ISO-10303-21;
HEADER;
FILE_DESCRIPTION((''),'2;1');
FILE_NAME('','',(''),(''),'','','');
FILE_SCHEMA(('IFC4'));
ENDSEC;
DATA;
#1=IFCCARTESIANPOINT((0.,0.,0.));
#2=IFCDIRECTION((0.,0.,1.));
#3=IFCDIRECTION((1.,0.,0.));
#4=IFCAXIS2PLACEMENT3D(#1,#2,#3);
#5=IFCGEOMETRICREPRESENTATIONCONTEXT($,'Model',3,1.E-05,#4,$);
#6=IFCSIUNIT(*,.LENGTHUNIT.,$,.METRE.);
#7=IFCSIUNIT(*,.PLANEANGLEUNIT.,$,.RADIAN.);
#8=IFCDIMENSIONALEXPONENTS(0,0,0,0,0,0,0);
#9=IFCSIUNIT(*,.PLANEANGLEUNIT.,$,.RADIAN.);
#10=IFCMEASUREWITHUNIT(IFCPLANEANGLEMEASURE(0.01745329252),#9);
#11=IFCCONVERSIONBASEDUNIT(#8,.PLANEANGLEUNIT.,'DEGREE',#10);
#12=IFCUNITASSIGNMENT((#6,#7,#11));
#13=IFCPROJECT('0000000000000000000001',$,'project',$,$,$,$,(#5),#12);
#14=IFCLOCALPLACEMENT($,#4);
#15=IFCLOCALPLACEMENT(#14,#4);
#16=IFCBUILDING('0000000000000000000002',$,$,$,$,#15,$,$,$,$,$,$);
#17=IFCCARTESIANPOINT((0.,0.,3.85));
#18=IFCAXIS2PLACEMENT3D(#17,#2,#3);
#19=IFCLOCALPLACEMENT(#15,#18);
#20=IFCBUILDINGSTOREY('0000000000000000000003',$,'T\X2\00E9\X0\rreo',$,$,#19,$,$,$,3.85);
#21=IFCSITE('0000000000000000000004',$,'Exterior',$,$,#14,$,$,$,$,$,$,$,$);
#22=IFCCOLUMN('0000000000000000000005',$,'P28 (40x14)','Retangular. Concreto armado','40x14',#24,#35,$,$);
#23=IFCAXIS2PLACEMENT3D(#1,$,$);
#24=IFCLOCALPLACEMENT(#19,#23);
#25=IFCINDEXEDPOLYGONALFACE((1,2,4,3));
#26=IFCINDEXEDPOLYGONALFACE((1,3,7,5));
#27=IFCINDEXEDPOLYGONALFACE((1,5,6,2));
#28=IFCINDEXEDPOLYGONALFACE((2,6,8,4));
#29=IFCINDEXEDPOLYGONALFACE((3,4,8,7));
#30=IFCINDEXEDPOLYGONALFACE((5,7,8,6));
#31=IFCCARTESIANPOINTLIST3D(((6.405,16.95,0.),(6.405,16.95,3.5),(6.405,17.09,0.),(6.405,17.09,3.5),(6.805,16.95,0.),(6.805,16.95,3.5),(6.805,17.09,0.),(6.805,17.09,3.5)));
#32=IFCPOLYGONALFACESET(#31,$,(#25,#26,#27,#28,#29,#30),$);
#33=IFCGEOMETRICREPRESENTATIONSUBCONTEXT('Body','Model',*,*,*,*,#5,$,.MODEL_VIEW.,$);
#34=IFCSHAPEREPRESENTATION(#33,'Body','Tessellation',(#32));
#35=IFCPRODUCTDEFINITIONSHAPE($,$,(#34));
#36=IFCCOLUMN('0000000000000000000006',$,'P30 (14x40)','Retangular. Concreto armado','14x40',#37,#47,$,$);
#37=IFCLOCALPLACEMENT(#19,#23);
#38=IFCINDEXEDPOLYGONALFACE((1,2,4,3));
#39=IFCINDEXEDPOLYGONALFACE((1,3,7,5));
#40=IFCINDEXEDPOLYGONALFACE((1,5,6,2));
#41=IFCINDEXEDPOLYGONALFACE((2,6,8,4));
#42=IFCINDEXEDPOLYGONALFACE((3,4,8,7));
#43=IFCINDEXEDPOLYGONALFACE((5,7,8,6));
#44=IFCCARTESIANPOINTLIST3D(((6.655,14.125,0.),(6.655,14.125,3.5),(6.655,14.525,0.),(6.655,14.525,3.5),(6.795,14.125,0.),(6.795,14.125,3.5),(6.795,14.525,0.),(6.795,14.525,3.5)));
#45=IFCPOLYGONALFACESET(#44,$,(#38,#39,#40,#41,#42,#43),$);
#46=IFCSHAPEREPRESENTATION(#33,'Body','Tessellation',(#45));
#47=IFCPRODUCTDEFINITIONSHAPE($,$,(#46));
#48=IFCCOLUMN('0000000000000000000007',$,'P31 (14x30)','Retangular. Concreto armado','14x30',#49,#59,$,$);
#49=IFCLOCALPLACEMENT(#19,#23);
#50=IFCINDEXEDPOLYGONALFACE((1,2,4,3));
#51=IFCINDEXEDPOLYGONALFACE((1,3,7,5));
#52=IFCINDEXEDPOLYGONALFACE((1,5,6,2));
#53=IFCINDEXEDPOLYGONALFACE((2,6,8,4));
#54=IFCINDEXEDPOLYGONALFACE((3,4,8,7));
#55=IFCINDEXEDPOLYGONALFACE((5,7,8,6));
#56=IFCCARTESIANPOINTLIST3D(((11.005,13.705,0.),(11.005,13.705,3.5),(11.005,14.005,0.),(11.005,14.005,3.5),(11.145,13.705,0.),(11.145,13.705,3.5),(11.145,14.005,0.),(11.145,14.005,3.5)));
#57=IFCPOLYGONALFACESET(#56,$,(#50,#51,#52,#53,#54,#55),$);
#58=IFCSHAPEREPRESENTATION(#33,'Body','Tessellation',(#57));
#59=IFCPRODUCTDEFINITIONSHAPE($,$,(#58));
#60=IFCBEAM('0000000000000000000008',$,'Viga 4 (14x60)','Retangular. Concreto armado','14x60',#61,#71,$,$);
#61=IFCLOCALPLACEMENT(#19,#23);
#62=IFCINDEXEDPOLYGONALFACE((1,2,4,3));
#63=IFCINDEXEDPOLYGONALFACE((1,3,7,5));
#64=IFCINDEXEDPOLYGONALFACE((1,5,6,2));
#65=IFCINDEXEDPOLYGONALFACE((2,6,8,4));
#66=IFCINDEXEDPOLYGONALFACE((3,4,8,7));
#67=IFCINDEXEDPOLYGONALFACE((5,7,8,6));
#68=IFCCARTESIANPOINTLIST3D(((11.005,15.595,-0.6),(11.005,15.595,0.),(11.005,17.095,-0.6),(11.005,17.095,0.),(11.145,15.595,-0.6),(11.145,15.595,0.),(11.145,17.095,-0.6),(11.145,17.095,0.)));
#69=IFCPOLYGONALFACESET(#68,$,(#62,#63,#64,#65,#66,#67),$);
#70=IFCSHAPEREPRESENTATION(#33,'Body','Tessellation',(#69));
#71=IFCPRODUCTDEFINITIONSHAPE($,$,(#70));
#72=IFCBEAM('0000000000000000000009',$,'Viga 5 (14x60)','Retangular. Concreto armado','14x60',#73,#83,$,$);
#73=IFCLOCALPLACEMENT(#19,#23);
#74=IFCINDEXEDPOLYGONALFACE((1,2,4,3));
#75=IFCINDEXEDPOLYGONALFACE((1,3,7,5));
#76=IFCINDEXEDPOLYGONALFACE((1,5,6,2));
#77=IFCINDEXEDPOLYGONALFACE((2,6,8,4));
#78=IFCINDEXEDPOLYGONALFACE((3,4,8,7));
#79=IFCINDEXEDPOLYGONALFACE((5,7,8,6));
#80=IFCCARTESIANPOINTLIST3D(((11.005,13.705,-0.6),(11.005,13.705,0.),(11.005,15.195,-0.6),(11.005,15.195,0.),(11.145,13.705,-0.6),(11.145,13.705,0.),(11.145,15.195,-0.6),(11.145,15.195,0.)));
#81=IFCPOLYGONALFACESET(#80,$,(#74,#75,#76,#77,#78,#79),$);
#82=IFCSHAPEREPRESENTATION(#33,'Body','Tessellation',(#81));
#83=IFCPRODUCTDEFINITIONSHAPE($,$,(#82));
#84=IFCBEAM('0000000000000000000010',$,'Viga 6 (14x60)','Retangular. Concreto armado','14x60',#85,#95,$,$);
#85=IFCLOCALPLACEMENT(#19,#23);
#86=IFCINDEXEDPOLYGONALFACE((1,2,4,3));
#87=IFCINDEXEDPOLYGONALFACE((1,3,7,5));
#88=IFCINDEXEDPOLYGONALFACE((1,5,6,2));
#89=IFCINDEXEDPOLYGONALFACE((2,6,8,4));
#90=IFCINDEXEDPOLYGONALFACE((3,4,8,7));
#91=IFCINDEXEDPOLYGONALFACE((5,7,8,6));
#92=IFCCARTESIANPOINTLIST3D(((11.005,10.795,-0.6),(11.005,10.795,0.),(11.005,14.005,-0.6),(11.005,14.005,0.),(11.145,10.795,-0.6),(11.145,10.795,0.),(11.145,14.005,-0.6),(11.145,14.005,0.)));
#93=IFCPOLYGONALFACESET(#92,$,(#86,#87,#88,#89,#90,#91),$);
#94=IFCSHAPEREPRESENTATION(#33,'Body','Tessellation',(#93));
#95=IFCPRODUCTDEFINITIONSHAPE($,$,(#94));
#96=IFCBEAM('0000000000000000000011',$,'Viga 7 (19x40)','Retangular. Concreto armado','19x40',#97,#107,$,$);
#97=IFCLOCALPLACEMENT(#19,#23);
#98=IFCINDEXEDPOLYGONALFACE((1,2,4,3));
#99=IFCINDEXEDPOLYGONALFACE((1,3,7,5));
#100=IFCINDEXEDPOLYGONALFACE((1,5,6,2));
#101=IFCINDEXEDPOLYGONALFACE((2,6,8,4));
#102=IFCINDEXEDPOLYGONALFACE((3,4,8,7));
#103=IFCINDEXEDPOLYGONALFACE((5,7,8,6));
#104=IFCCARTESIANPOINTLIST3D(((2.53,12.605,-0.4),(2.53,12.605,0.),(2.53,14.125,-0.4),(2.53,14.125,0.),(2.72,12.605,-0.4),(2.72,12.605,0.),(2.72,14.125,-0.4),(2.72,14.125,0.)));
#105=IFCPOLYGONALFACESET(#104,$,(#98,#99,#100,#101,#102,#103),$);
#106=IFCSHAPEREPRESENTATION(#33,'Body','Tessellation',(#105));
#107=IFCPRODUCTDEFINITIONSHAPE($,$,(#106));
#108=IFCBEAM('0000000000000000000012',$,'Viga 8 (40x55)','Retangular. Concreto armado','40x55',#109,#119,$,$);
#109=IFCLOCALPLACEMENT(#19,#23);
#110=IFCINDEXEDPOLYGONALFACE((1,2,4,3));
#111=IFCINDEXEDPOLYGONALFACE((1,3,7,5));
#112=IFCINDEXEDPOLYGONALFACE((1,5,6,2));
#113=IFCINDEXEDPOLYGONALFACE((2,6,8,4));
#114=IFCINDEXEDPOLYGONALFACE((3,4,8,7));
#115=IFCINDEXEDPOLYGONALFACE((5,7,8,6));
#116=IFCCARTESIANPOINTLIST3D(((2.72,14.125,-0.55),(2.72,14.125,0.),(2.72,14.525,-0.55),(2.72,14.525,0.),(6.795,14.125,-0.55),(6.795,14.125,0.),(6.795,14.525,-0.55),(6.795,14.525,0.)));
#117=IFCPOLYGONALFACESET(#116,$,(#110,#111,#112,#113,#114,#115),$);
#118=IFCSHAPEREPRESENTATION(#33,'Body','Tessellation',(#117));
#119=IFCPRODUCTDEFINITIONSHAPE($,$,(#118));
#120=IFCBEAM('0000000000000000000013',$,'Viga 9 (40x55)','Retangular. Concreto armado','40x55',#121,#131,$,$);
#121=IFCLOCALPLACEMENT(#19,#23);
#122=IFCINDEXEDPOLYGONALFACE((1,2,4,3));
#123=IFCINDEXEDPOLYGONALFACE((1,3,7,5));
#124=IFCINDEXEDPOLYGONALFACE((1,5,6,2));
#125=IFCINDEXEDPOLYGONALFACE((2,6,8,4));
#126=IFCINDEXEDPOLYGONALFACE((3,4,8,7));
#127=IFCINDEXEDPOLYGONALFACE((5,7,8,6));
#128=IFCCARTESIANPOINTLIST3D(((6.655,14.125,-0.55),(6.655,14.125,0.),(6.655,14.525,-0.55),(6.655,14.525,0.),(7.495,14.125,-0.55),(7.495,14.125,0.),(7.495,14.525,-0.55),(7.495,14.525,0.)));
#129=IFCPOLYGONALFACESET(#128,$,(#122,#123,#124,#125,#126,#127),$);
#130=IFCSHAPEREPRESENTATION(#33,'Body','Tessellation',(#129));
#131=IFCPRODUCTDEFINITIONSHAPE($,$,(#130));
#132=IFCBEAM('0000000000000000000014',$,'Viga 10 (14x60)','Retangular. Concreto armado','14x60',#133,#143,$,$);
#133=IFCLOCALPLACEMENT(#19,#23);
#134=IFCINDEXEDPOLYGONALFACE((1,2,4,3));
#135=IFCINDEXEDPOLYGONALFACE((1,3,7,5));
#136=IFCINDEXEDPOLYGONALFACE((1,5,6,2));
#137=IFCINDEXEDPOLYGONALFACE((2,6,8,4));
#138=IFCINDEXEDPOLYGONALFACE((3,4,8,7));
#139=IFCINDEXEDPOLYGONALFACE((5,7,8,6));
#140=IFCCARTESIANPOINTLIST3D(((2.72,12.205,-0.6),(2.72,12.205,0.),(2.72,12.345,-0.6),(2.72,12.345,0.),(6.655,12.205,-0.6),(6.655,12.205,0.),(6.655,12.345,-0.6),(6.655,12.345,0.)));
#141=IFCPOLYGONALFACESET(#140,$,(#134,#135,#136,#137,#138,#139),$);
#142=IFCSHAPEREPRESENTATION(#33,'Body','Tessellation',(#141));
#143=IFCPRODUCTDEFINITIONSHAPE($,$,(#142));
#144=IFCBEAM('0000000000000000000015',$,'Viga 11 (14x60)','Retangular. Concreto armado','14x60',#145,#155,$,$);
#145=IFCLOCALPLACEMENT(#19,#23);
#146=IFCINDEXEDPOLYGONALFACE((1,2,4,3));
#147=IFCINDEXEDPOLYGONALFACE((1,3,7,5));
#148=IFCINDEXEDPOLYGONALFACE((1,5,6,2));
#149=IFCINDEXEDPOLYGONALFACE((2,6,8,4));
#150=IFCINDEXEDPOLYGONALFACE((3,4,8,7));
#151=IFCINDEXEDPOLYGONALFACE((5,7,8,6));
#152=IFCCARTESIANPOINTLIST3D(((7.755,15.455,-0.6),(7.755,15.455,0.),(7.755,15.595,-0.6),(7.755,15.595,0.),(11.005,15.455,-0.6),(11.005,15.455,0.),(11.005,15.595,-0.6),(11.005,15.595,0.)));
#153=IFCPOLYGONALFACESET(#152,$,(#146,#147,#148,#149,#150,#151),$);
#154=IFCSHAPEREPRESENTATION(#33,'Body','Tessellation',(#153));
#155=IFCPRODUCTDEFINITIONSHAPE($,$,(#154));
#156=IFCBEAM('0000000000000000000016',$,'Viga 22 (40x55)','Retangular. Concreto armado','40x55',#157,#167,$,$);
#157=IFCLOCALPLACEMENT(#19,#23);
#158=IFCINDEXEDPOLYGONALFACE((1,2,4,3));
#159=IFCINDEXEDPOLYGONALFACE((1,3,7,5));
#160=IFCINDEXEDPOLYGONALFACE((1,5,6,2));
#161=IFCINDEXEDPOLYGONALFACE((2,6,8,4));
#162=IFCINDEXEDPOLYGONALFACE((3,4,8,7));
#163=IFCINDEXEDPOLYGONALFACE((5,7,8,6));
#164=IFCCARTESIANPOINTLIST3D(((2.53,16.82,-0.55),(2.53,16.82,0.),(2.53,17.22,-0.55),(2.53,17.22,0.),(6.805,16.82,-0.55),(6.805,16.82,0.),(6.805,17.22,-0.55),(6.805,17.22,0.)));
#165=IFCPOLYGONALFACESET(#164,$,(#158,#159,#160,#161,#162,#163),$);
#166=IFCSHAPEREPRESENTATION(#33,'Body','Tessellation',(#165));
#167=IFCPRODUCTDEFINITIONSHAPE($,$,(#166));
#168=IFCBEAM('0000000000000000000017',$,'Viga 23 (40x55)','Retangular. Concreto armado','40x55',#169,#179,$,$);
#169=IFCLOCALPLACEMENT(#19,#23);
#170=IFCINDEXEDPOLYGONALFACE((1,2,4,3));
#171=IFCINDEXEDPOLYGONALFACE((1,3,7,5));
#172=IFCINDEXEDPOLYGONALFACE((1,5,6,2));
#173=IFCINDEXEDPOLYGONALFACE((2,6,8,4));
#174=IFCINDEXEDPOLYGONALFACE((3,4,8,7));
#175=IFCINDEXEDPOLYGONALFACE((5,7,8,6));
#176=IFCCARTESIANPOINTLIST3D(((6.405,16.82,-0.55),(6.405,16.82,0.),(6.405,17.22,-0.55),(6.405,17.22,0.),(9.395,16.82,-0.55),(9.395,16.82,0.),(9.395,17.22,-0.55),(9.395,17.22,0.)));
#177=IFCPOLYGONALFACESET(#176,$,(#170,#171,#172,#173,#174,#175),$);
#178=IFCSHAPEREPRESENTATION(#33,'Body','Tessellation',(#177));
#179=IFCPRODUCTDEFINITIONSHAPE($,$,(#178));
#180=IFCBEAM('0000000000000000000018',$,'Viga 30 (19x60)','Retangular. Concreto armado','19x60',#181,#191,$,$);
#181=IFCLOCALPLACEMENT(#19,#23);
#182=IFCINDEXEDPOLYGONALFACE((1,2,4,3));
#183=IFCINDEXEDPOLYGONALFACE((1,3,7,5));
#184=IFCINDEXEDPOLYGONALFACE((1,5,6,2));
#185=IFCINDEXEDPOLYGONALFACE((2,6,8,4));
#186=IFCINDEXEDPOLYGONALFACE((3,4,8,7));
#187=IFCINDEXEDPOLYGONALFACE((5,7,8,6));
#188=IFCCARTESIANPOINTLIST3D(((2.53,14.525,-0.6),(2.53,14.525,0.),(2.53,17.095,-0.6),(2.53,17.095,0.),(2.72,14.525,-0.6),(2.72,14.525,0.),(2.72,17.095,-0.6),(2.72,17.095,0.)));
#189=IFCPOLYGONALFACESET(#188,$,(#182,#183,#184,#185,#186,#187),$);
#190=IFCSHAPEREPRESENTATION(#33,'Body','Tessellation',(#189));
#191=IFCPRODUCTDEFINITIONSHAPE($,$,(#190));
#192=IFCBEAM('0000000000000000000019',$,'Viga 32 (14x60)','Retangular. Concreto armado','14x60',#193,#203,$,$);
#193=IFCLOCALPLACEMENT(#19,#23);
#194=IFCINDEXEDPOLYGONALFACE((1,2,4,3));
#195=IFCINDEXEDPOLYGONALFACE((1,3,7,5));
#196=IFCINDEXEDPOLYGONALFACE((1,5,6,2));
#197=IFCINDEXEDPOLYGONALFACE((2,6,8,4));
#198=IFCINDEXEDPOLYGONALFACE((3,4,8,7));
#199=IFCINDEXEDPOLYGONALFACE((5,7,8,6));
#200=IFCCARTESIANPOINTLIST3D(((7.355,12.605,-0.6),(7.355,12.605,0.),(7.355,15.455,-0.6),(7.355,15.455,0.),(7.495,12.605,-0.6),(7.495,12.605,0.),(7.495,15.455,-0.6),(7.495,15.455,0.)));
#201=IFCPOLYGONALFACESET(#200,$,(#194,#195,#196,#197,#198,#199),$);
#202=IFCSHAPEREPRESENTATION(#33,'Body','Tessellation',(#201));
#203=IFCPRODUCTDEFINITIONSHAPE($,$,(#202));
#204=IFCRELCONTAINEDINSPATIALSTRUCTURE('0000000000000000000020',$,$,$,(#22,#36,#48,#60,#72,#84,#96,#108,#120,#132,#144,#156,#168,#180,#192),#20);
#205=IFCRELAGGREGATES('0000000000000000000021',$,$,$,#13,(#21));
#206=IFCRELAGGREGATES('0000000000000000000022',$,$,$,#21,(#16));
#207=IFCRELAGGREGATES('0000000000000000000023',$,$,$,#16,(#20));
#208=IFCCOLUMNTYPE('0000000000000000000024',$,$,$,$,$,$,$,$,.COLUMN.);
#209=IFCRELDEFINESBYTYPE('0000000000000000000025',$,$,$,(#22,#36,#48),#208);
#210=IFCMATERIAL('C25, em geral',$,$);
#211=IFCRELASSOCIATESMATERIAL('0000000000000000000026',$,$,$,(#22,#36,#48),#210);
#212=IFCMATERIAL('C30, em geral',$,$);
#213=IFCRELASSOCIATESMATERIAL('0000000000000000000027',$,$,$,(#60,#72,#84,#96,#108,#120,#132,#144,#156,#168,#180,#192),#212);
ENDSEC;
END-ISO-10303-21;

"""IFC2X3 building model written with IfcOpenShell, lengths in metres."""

from ifc_helpers import new_model, entity, si_unit, converted_unit, frame, frame_2d, origin_with_axes, place, context, subcontext, project, spatial, rectangle, extrude, material, type_object, element, save


model = new_model("IFC2X3")

# Units and contexts
model_context = context("Model", 3, precision=1e-05, world=origin_with_axes())
body_context = subcontext(model_context, "Body", "Model", "MODEL_VIEW")
ifc_project = project(units=[si_unit("LENGTHUNIT", "METRE"), si_unit("PLANEANGLEUNIT", "RADIAN"), converted_unit("PLANEANGLEUNIT", "DEGREE", entity("IfcPlaneAngleMeasure", 0.01745329252), si_unit("PLANEANGLEUNIT", "RADIAN"), dimensions=[0, 0, 0, 0, 0, 0, 0])], contexts=[model_context])

# Site, building, storey
site_placement = place(None, origin_with_axes())
site = spatial("IfcSite", under=ifc_project, at=site_placement, Name="Exterior")
building_placement = place(site_placement, origin_with_axes())
building = spatial("IfcBuilding", under=site, at=building_placement)
storey_placement = place(building_placement, frame((0.0, 0.0, 3.85), z_axis=(0.0, 0.0, 1.0), x_axis=(1.0, 0.0, 0.0)))
storey = spatial("IfcBuildingStorey", under=building, at=storey_placement, Name="Térreo", Elevation=3.85)

# Columns
ifc_material_1 = material(Name="C25, em geral")
column_type = type_object("IfcColumnType", PredefinedType="COLUMN")
column_1_placement = place(storey_placement, frame((6.405, 16.95, 0.0), z_axis=(0.0, 0.0, 1.0), x_axis=(1.0, 0.0, 0.0)))
element("IfcColumn", 1, at=column_1_placement, inside=storey, type_object=column_type, material=ifc_material_1, Name="P28 (40x14)", Description="Retangular. Concreto armado", ObjectType="40x14", context=body_context, shape_type="SweptSolid", body=[
    extrude(rectangle(XDim=0.4, YDim=0.14, at=frame_2d((0.2, 0.07), x_axis=(1.0, 0.0))), origin_with_axes(), (0.0, 0.0, 1.0), 3.5),
])
column_2_placement = place(storey_placement, frame((6.795, 14.525, 0.0), z_axis=(0.0, 0.0, 1.0), x_axis=(1.0, 0.0, 0.0)))
element("IfcColumn", 2, at=column_2_placement, inside=storey, type_object=column_type, material=ifc_material_1, Name="P30 (14x40)", Description="Retangular. Concreto armado", ObjectType="14x40", context=body_context, shape_type="SweptSolid", body=[
    extrude(rectangle(XDim=0.14, YDim=0.4, at=frame_2d((-0.07, -0.2), x_axis=(1.0, 0.0))), origin_with_axes(), (0.0, 0.0, 1.0), 3.5),
])
column_3_placement = place(storey_placement, frame((11.005, 13.705, 0.0), z_axis=(0.0, 0.0, 1.0), x_axis=(1.0, 0.0, 0.0)))
element("IfcColumn", 3, at=column_3_placement, inside=storey, type_object=column_type, material=ifc_material_1, Name="P31 (14x30)", Description="Retangular. Concreto armado", ObjectType="14x30", context=body_context, shape_type="SweptSolid", body=[
    extrude(rectangle(XDim=0.14, YDim=0.3, at=frame_2d((0.07, 0.15), x_axis=(1.0, 0.0))), origin_with_axes(), (0.0, 0.0, 1.0), 3.5),
])

# Beams
ifc_material_2 = material(Name="C30, em geral")
beam_1_placement = place(storey_placement, frame((11.075, 17.095, 0.0), z_axis=(0.0, -1.0, 0.0), x_axis=(1.0, 0.0, 0.0)))
element("IfcBeam", 4, at=beam_1_placement, inside=storey, material=ifc_material_2, Name="Viga 4 (14x60)", Description="Retangular. Concreto armado", ObjectType="14x60", context=body_context, shape_type="SweptSolid", body=[
    extrude(rectangle(XDim=0.14, YDim=0.6, at=frame_2d((0.0, -0.3), x_axis=(1.0, 0.0))), origin_with_axes(), (0.0, 0.0, 1.0), 1.5),
])
beam_2_placement = place(storey_placement, frame((11.075, 15.195, 0.0), z_axis=(0.0, -1.0, 0.0), x_axis=(1.0, 0.0, 0.0)))
element("IfcBeam", 5, at=beam_2_placement, inside=storey, material=ifc_material_2, Name="Viga 5 (14x60)", Description="Retangular. Concreto armado", ObjectType="14x60", context=body_context, shape_type="SweptSolid", body=[
    extrude(rectangle(XDim=0.14, YDim=0.6, at=frame_2d((0.0, -0.3), x_axis=(1.0, 0.0))), origin_with_axes(), (0.0, 0.0, 1.0), 1.49),
])
beam_3_placement = place(storey_placement, frame((11.075, 14.005, 0.0), z_axis=(0.0, -1.0, 0.0), x_axis=(1.0, 0.0, 0.0)))
element("IfcBeam", 6, at=beam_3_placement, inside=storey, material=ifc_material_2, Name="Viga 6 (14x60)", Description="Retangular. Concreto armado", ObjectType="14x60", context=body_context, shape_type="SweptSolid", body=[
    extrude(rectangle(XDim=0.14, YDim=0.6, at=frame_2d((0.0, -0.3), x_axis=(1.0, 0.0))), origin_with_axes(), (0.0, 0.0, 1.0), 3.21),
])
beam_4_placement = place(storey_placement, frame((2.625, 14.125, 0.0), z_axis=(0.0, -1.0, 0.0), x_axis=(1.0, 0.0, 0.0)))
element("IfcBeam", 7, at=beam_4_placement, inside=storey, material=ifc_material_2, Name="Viga 7 (19x40)", Description="Retangular. Concreto armado", ObjectType="19x40", context=body_context, shape_type="SweptSolid", body=[
    extrude(rectangle(XDim=0.19, YDim=0.4, at=frame_2d((0.0, -0.2), x_axis=(1.0, 0.0))), origin_with_axes(), (0.0, 0.0, 1.0), 1.52),
])
beam_5_placement = place(storey_placement, frame((2.72, 14.325, 0.0), z_axis=(1.0, 0.0, 0.0), x_axis=(0.0, 1.0, 0.0)))
element("IfcBeam", 8, at=beam_5_placement, inside=storey, material=ifc_material_2, Name="Viga 8 (40x55)", Description="Retangular. Concreto armado", ObjectType="40x55", context=body_context, shape_type="SweptSolid", body=[
    extrude(rectangle(XDim=0.4, YDim=0.55, at=frame_2d((0.0, -0.275), x_axis=(1.0, 0.0))), origin_with_axes(), (0.0, 0.0, 1.0), 4.075),
])
beam_6_placement = place(storey_placement, frame((6.655, 14.325, 0.0), z_axis=(1.0, 0.0, 0.0), x_axis=(0.0, 1.0, 0.0)))
element("IfcBeam", 9, at=beam_6_placement, inside=storey, material=ifc_material_2, Name="Viga 9 (40x55)", Description="Retangular. Concreto armado", ObjectType="40x55", context=body_context, shape_type="SweptSolid", body=[
    extrude(rectangle(XDim=0.4, YDim=0.55, at=frame_2d((0.0, -0.275), x_axis=(1.0, 0.0))), origin_with_axes(), (0.0, 0.0, 1.0), 0.84),
])
beam_7_placement = place(storey_placement, frame((2.72, 12.275, 0.0), z_axis=(1.0, 0.0, 0.0), x_axis=(0.0, 1.0, 0.0)))
element("IfcBeam", 10, at=beam_7_placement, inside=storey, material=ifc_material_2, Name="Viga 10 (14x60)", Description="Retangular. Concreto armado", ObjectType="14x60", context=body_context, shape_type="SweptSolid", body=[
    extrude(rectangle(XDim=0.14, YDim=0.6, at=frame_2d((0.0, -0.3), x_axis=(1.0, 0.0))), origin_with_axes(), (0.0, 0.0, 1.0), 3.935),
])
beam_8_placement = place(storey_placement, frame((7.755, 15.525, 0.0), z_axis=(1.0, 0.0, 0.0), x_axis=(0.0, 1.0, 0.0)))
element("IfcBeam", 11, at=beam_8_placement, inside=storey, material=ifc_material_2, Name="Viga 11 (14x60)", Description="Retangular. Concreto armado", ObjectType="14x60", context=body_context, shape_type="SweptSolid", body=[
    extrude(rectangle(XDim=0.14, YDim=0.6, at=frame_2d((0.0, -0.3), x_axis=(1.0, 0.0))), origin_with_axes(), (0.0, 0.0, 1.0), 3.25),
])
beam_9_placement = place(storey_placement, frame((6.805, 17.02, 0.0), z_axis=(-1.0, 0.0, 0.0), x_axis=(0.0, -1.0, 0.0)))
element("IfcBeam", 12, at=beam_9_placement, inside=storey, material=ifc_material_2, Name="Viga 22 (40x55)", Description="Retangular. Concreto armado", ObjectType="40x55", context=body_context, shape_type="SweptSolid", body=[
    extrude(rectangle(XDim=0.4, YDim=0.55, at=frame_2d((0.0, -0.275), x_axis=(1.0, 0.0))), origin_with_axes(), (0.0, 0.0, 1.0), 4.275),
])
beam_10_placement = place(storey_placement, frame((6.405, 17.02, 0.0), z_axis=(1.0, 0.0, 0.0), x_axis=(0.0, 1.0, 0.0)))
element("IfcBeam", 13, at=beam_10_placement, inside=storey, material=ifc_material_2, Name="Viga 23 (40x55)", Description="Retangular. Concreto armado", ObjectType="40x55", context=body_context, shape_type="SweptSolid", body=[
    extrude(rectangle(XDim=0.4, YDim=0.55, at=frame_2d((0.0, -0.275), x_axis=(1.0, 0.0))), origin_with_axes(), (0.0, 0.0, 1.0), 2.99),
])
beam_11_placement = place(storey_placement, frame((2.625, 14.525, 0.0), z_axis=(0.0, 1.0, 0.0), x_axis=(-1.0, 0.0, 0.0)))
element("IfcBeam", 14, at=beam_11_placement, inside=storey, material=ifc_material_2, Name="Viga 30 (19x60)", Description="Retangular. Concreto armado", ObjectType="19x60", context=body_context, shape_type="SweptSolid", body=[
    extrude(rectangle(XDim=0.19, YDim=0.6, at=frame_2d((0.0, -0.3), x_axis=(1.0, 0.0))), origin_with_axes(), (0.0, 0.0, 1.0), 2.57),
])
beam_12_placement = place(storey_placement, frame((7.425, 15.455, 0.0), z_axis=(0.0, -1.0, 0.0), x_axis=(1.0, 0.0, 0.0)))
element("IfcBeam", 15, at=beam_12_placement, inside=storey, material=ifc_material_2, Name="Viga 32 (14x60)", Description="Retangular. Concreto armado", ObjectType="14x60", context=body_context, shape_type="SweptSolid", body=[
    extrude(rectangle(XDim=0.14, YDim=0.6, at=frame_2d((0.0, -0.3), x_axis=(1.0, 0.0))), origin_with_axes(), (0.0, 0.0, 1.0), 2.85),
])

save(model, "model.ifc")
